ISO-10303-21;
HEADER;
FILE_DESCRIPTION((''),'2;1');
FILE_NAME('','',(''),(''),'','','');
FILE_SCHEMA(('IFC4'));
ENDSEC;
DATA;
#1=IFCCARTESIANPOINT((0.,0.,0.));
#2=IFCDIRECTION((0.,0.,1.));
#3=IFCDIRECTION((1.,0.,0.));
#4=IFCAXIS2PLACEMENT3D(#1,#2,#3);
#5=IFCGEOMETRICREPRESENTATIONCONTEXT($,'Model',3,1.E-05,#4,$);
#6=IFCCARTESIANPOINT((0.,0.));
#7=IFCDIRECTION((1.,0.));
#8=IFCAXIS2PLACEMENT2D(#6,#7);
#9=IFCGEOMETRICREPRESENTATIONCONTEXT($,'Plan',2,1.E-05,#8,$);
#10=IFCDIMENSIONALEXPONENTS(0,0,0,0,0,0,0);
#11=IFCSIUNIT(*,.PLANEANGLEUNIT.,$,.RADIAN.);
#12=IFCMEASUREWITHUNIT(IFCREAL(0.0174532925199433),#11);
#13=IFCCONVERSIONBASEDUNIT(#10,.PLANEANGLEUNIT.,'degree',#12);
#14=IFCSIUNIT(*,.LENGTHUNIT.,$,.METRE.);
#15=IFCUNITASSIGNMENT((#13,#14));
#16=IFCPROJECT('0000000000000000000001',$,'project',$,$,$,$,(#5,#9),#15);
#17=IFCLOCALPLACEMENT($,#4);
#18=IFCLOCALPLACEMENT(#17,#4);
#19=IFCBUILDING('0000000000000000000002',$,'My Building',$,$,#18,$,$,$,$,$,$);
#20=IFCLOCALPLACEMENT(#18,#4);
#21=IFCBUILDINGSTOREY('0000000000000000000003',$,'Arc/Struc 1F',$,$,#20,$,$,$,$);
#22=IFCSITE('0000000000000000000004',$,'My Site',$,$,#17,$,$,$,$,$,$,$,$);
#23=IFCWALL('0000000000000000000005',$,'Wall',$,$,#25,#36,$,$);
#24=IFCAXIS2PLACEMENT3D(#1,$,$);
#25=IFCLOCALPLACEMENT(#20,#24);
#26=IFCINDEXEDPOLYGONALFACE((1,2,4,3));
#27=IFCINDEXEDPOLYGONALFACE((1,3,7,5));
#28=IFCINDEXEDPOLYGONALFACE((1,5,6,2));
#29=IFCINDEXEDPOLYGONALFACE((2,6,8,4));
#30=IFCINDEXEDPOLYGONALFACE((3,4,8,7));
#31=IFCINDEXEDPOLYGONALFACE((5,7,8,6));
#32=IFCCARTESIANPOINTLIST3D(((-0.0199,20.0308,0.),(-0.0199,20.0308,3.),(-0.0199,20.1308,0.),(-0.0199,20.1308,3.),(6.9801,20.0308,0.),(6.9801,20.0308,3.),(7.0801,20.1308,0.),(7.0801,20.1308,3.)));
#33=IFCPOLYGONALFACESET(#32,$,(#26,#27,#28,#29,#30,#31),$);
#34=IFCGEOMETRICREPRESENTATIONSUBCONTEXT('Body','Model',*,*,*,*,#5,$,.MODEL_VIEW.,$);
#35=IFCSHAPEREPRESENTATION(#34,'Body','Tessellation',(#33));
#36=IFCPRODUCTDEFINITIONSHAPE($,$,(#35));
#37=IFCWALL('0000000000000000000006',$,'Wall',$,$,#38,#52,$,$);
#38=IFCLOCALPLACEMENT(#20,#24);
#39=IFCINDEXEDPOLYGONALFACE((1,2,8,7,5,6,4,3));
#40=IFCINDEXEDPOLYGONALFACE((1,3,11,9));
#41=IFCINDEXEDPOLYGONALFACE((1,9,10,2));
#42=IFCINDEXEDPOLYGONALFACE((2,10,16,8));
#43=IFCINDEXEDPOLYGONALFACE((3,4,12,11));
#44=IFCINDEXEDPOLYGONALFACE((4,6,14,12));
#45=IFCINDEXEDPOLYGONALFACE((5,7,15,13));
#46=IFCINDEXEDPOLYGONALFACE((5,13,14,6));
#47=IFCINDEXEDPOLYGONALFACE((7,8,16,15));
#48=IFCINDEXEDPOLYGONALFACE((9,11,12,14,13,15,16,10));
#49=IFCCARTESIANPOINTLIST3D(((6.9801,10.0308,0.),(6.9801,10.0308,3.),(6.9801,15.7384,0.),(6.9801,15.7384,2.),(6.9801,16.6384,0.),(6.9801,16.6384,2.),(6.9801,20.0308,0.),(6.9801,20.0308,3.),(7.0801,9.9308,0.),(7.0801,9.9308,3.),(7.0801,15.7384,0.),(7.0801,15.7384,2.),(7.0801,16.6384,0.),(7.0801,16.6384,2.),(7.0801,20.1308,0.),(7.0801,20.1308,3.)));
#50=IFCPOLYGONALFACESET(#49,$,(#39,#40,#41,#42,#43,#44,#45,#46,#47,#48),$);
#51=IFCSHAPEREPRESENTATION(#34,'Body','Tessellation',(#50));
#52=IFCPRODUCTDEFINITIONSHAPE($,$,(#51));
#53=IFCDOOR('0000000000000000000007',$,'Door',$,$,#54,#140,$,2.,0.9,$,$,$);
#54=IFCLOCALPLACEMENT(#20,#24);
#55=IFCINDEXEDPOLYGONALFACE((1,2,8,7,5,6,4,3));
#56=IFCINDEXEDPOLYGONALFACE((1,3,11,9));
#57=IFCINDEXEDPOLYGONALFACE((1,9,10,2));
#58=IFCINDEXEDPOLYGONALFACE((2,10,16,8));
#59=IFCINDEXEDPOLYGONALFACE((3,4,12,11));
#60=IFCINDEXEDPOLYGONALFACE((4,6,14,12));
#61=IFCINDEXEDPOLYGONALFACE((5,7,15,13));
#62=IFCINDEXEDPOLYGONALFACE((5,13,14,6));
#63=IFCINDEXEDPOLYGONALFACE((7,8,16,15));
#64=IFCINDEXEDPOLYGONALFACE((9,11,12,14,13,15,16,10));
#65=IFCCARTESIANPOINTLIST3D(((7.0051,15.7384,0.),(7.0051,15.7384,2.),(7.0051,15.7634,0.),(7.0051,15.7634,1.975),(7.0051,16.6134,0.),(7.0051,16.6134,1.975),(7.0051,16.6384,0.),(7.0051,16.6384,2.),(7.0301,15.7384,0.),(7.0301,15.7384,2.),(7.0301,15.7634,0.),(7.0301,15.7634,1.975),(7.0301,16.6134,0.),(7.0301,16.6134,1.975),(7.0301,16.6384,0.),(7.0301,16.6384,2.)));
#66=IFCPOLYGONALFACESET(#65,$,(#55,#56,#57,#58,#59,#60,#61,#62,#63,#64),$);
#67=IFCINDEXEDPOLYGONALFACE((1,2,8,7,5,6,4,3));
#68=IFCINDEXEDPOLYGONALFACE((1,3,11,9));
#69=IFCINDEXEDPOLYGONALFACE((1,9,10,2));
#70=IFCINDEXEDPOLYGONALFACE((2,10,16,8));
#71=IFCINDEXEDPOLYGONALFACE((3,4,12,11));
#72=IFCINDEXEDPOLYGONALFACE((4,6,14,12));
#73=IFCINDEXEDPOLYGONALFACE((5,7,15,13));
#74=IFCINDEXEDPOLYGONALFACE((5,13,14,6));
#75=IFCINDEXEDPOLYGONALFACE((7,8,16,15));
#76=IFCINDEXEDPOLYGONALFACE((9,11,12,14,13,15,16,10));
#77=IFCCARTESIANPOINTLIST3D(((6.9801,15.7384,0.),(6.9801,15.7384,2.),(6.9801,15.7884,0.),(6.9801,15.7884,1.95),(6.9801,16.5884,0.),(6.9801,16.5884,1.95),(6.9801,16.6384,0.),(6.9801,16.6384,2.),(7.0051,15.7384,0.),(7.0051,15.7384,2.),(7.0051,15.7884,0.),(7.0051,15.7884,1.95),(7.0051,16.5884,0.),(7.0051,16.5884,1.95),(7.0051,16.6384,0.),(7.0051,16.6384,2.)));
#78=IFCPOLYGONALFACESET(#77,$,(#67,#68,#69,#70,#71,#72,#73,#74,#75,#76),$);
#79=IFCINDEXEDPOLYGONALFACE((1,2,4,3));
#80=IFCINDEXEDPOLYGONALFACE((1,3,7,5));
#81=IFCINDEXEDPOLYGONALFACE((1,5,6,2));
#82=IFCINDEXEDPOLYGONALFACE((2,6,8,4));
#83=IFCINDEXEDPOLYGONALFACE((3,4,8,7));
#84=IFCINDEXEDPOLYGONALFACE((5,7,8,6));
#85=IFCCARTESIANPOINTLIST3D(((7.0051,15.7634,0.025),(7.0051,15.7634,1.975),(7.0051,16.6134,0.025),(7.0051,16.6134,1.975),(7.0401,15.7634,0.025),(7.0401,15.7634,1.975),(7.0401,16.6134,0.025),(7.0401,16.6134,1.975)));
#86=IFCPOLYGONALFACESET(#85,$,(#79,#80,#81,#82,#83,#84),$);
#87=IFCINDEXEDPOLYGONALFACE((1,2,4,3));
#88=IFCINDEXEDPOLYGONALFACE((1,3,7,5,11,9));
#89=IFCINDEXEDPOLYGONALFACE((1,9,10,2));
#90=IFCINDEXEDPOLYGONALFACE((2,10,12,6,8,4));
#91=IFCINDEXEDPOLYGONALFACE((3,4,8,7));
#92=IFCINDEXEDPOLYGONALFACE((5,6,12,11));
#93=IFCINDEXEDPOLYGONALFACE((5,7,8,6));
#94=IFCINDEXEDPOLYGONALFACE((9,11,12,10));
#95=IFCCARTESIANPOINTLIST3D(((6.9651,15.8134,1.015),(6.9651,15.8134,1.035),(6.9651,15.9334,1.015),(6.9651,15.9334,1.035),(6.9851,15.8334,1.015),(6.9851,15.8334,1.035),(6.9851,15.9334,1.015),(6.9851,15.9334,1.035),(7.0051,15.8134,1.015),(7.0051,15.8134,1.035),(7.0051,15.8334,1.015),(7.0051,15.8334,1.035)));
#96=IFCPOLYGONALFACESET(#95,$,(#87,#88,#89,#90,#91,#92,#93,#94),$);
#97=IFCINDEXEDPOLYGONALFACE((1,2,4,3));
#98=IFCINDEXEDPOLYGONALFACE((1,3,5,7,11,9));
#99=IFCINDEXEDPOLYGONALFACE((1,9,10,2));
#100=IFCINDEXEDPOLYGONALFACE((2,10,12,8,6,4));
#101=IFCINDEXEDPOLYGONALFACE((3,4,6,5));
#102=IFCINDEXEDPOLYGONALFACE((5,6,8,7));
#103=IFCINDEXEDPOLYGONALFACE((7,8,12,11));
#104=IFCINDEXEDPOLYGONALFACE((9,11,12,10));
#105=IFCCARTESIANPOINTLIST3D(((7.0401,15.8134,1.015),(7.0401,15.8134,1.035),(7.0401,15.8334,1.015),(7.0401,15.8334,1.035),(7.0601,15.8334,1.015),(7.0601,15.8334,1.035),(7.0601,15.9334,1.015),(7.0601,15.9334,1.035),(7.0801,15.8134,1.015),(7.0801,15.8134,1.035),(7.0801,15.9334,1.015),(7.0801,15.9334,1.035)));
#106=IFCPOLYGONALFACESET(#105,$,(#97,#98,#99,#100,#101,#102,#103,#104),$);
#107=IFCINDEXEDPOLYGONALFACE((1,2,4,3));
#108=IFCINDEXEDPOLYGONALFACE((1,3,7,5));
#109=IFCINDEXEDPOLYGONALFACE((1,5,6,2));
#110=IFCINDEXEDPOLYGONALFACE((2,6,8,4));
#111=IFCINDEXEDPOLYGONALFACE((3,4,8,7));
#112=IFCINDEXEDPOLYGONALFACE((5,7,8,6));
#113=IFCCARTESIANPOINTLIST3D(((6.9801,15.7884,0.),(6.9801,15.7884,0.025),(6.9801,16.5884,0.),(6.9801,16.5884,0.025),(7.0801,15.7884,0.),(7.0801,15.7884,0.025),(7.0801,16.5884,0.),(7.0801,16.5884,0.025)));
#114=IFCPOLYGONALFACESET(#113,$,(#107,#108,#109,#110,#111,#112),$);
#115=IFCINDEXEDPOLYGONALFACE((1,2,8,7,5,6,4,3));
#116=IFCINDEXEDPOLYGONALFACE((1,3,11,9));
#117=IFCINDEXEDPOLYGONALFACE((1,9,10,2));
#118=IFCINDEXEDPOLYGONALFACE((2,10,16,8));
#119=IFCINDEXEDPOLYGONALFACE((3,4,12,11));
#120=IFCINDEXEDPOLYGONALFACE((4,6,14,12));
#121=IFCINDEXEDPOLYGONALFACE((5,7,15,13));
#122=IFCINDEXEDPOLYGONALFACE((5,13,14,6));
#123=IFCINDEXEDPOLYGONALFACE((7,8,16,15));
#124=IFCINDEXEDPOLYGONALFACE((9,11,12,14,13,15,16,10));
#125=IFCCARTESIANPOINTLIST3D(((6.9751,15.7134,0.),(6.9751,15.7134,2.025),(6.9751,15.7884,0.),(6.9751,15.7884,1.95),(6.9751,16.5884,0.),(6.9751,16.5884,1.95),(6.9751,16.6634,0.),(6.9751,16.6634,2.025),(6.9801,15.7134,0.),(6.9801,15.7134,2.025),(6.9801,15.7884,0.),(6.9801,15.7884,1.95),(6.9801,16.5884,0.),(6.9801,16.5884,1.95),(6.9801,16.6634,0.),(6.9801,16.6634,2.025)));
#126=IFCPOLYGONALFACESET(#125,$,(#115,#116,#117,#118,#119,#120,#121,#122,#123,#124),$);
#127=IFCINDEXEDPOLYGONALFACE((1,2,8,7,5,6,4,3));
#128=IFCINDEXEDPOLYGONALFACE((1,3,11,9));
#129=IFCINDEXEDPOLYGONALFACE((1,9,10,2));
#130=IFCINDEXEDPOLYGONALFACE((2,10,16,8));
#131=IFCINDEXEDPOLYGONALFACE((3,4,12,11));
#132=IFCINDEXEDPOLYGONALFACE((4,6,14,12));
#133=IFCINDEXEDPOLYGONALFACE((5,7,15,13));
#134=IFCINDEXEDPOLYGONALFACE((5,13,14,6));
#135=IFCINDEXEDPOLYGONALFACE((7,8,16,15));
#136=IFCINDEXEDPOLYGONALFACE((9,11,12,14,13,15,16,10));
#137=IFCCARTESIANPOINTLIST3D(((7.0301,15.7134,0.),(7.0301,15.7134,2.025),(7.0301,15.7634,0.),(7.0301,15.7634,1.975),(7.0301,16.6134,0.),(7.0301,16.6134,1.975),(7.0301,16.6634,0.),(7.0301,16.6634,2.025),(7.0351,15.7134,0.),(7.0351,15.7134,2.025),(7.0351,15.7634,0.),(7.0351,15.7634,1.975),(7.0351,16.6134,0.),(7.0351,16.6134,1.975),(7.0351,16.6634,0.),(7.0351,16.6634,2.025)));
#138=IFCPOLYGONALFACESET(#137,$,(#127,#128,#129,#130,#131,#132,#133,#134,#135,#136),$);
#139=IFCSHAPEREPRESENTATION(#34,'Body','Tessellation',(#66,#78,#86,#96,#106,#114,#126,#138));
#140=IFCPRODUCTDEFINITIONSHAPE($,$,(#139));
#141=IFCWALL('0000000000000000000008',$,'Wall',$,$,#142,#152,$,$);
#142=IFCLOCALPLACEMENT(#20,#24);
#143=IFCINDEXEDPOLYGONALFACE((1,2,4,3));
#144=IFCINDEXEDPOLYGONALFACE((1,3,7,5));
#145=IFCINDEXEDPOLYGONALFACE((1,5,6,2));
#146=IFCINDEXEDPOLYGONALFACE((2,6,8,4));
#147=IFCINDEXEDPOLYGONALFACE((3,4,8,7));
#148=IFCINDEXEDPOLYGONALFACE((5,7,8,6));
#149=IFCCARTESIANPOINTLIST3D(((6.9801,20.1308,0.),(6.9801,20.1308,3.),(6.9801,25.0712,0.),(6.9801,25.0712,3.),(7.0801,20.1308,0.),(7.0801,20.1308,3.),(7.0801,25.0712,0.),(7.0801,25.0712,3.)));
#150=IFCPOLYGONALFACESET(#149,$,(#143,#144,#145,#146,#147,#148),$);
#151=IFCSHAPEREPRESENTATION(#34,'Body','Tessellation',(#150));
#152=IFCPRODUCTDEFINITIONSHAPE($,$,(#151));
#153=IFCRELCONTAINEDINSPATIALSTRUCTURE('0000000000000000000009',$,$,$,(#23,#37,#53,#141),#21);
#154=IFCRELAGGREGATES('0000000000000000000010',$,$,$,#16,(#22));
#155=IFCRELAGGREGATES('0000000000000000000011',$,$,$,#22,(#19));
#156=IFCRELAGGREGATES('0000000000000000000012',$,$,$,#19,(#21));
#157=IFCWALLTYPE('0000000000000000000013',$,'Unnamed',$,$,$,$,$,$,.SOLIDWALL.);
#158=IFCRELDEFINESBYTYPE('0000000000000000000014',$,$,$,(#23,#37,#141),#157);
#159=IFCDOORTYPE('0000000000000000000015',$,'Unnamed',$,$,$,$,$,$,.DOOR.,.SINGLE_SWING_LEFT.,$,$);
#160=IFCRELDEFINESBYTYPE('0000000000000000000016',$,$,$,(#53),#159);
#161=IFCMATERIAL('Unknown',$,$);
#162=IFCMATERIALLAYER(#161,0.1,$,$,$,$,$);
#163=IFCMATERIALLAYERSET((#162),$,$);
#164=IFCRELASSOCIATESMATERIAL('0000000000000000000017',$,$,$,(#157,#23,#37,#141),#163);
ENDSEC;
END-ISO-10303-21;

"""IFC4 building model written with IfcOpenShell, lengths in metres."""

from ifc_helpers import new_model, entity, si_unit, converted_unit, frame, origin_with_axes, origin_2d_with_axis, place, context, subcontext, project, spatial, line, indexed_curve, outline, extrude, shape, source, transform, mapped, material, layer, layer_set, layer_usage, type_object, type_shapes, element, fill, save


model = new_model("IFC4")

# Units and contexts
model_context = context("Model", 3, precision=1e-05, world=origin_with_axes())
plan_context = context("Plan", 2, precision=1e-05, world=origin_2d_with_axis())
body_context_1 = subcontext(model_context, "Body", "Model", "MODEL_VIEW")
body_context_2 = subcontext(plan_context, "Body", "Plan", "PLAN_VIEW")
ifc_project = project(units=[converted_unit("PLANEANGLEUNIT", "degree", entity("IfcReal", 0.0174532925199433), si_unit("PLANEANGLEUNIT", "RADIAN"), dimensions=[0, 0, 0, 0, 0, 0, 0]), si_unit("LENGTHUNIT", "METRE")], contexts=[model_context, plan_context])

# Site, building, storey
site_placement = place(None, origin_with_axes())
site = spatial("IfcSite", under=ifc_project, at=site_placement, Name="My Site")
building_placement = place(site_placement, origin_with_axes())
building = spatial("IfcBuilding", under=site, at=building_placement, Name="My Building")
storey_placement = place(building_placement, origin_with_axes())
storey = spatial("IfcBuildingStorey", under=building, at=storey_placement, Name="Arc/Struc 1F")

# Shared definitions
ifc_material = material(Name="Unknown")

# Wall
ifc_layer_1 = layer(ifc_material, 0.1)
ifc_layer_set_1 = layer_set([ifc_layer_1])
wall_type = type_object("IfcWallType", Name="Unnamed", PredefinedType="SOLIDWALL", material=ifc_layer_set_1)
ifc_layer_usage_1 = layer_usage(ifc_layer_set_1, "AXIS2", "POSITIVE", 0.0)
wall_1_placement = place(storey_placement, frame((-0.0199, 20.0308, 0.0), z_axis=(0.0, 0.0, 1.0), x_axis=(1.0, 0.0, 0.0)))
element("IfcWall", 1, at=wall_1_placement, inside=storey, type_object=wall_type, material=ifc_layer_usage_1, Name="Wall", context=body_context_1, shape_type="SweptSolid", body=[
    extrude(outline(indexed_curve([(0.0, 0.0), (0.0, 0.1), (7.1, 0.1), (7.0, 0.0)], segments=[line(1, 2, 3, 4, 1)])), origin_with_axes(), (0.0, 0.0, 1.0), 3.0),
])

# Wall, opening, door
ifc_layer_usage_2 = layer_usage(ifc_layer_set_1, "AXIS2", "POSITIVE", 0.0)
wall_2_placement = place(storey_placement, frame((6.9801, 20.0308, 0.0), z_axis=(0.0, 0.0, 1.0), x_axis=(0.0, -1.0, 0.0)))
wall_2 = element("IfcWall", 2, at=wall_2_placement, inside=storey, type_object=wall_type, material=ifc_layer_usage_2, Name="Wall", context=body_context_1, shape_type="SweptSolid", body=[
    extrude(outline(indexed_curve([(0.0, 0.0), (-0.1, 0.1), (10.1, 0.1), (10.0, 0.0)], segments=[line(1, 2, 3, 4, 1)])), origin_with_axes(), (0.0, 0.0, 1.0), 3.0),
])
shared_shape_1 = source(origin_with_axes(), body_context_1, "Body", "SweptSolid", [
    extrude(outline(indexed_curve([(0.0, 0.0), (0.9, 0.0), (0.9, 2.0), (0.0, 2.0)], segments=[line(1, 2, 3, 4, 1)])), frame((0.0, -0.6, 0.0), z_axis=(0.0, -1.0, 0.0), x_axis=(1.0, 0.0, 0.0)), (0.0, 0.0, -1.0), 1.2),
])
opening_1_placement = place(wall_2_placement, frame((3.3924, 0.0, 0.0), z_axis=(0.0, 0.0, 1.0), x_axis=(1.0, 0.0, 0.0)))
opening_1 = element("IfcOpeningElement", 3, at=opening_1_placement, cuts=wall_2, PredefinedType="OPENING", context=body_context_1, shape_type="MappedRepresentation", body=[
    mapped(shared_shape_1, transform((0.0, 0.0, 0.0), x_axis=(1.0, 0.0, 0.0), y_axis=(0.0, 1.0, 0.0), z_axis=(0.0, 0.0, 1.0), scale=1.0)),
])
door_type = type_object("IfcDoorType", Name="Unnamed", OperationType="SINGLE_SWING_LEFT", PredefinedType="DOOR")
shared_shape_2 = source(origin_with_axes(), body_context_1, "Body", "SweptSolid", [
    extrude(outline(indexed_curve([(0.0, 0.0), (0.0, 2.0), (0.9, 2.0), (0.9, 0.0), (0.875, 0.0), (0.875, 1.975), (0.025, 1.975), (0.025, 0.0)], segments=[line(1, 2, 3, 4, 5, 6, 7, 8, 1)])), frame((0.0, 0.025, 0.0), z_axis=(0.0, -1.0, 0.0), x_axis=(1.0, 0.0, 0.0)), (0.0, 0.0, -1.0), 0.025),
    extrude(outline(indexed_curve([(0.0, 0.0), (0.0, 2.0), (0.9, 2.0), (0.9, 0.0), (0.85, 0.0), (0.85, 1.95), (0.05, 1.95), (0.05, 0.0)], segments=[line(1, 2, 3, 4, 5, 6, 7, 8, 1)])), frame((0.0, 0.0, 0.0), z_axis=(0.0, -1.0, 0.0), x_axis=(1.0, 0.0, 0.0)), (0.0, 0.0, -1.0), 0.025),
    extrude(outline(indexed_curve([(0.0, 0.0), (0.85, 0.0), (0.85, 0.035), (0.0, 0.035)], segments=[line(1, 2, 3, 4, 1)])), frame((0.025, 0.025, 0.025), z_axis=(0.0, 0.0, 1.0), x_axis=(1.0, 0.0, 0.0)), (0.0, 0.0, 1.0), 1.95),
    extrude(outline(indexed_curve([(0.0, 0.0), (0.0, -0.04), (-0.12, -0.04), (-0.12, -0.02), (-0.02, -0.02), (-0.02, 0.0)], segments=[line(1, 2, 3, 4, 5, 6, 1)])), frame((0.825, 0.025, 1.015), z_axis=(0.0, 0.0, 1.0), x_axis=(1.0, 0.0, 0.0)), (0.0, 0.0, 1.0), 0.02),
    extrude(outline(indexed_curve([(0.0, 0.0), (0.0, 0.04), (-0.12, 0.04), (-0.12, 0.02), (-0.02, 0.02), (-0.02, 0.0)], segments=[line(1, 2, 3, 4, 5, 6, 1)])), frame((0.825, 0.06, 1.015), z_axis=(0.0, 0.0, 1.0), x_axis=(1.0, 0.0, 0.0)), (0.0, 0.0, 1.0), 0.02),
    extrude(outline(indexed_curve([(0.0, 0.0), (0.8, 0.0), (0.8, 0.1), (0.0, 0.1)], segments=[line(1, 2, 3, 4, 1)])), frame((0.05, 0.0, 0.0), z_axis=(0.0, 0.0, 1.0), x_axis=(1.0, 0.0, 0.0)), (0.0, 0.0, 1.0), 0.025),
    extrude(outline(indexed_curve([(0.0, 0.0), (0.0, 2.025), (0.95, 2.025), (0.95, 0.0), (0.875, 0.0), (0.875, 1.95), (0.075, 1.95), (0.075, 0.0)], segments=[line(1, 2, 3, 4, 5, 6, 7, 8, 1)])), frame((-0.025, -0.005, 0.0), z_axis=(0.0, -1.0, 0.0), x_axis=(1.0, 0.0, 0.0)), (0.0, 0.0, -1.0), 0.005),
    extrude(outline(indexed_curve([(0.0, 0.0), (0.0, 2.025), (0.95, 2.025), (0.95, 0.0), (0.9, 0.0), (0.9, 1.975), (0.05, 1.975), (0.05, 0.0)], segments=[line(1, 2, 3, 4, 5, 6, 7, 8, 1)])), frame((-0.025, 0.05, 0.0), z_axis=(0.0, -1.0, 0.0), x_axis=(1.0, 0.0, 0.0)), (0.0, 0.0, -1.0), 0.005),
])
shared_shape_3 = source(origin_with_axes(), body_context_2, "Body", "Curve2D", [
    entity("IfcIndexedPolyCurve", entity("IfcCartesianPointList2D", [[0.0, 0.0], [0.0, 0.05], [0.025, 0.05], [0.025, 0.025], [0.05, 0.025], [0.05, 0.0]]), [entity("IfcLineIndex", [1, 2, 3, 4, 5, 6, 1])]),
    entity("IfcIndexedPolyCurve", entity("IfcCartesianPointList2D", [[0.9, 0.0], [0.9, 0.05], [0.875, 0.05], [0.875, 0.025], [0.85, 0.025], [0.85, 0.0]]), [entity("IfcLineIndex", [1, 2, 3, 4, 5, 6, 1])]),
    entity("IfcTrimmedCurve", entity("IfcEllipse", entity("IfcAxis2Placement2D", entity("IfcCartesianPoint", [0.06, 0.05]), entity("IfcDirection", [1.0, 0.0])), 0.815, 0.85), [entity("IfcCartesianPoint", [0.875, 0.05])], [entity("IfcCartesianPoint", [0.06, 0.9])], True, "CARTESIAN"),
    entity("IfcIndexedPolyCurve", entity("IfcCartesianPointList2D", [[0.025, 0.05], [0.06, 0.05], [0.06, 0.9], [0.025, 0.9]]), [entity("IfcLineIndex", [1, 2, 3, 4, 1])]),
])
type_shapes(door_type, [shared_shape_2, shared_shape_3])
door_1_placement = place(opening_1_placement, frame((0.0, 0.0, 0.0), z_axis=(0.0, 0.0, 1.0), x_axis=(1.0, 0.0, 0.0)))
door_1 = element("IfcDoor", 4, at=door_1_placement, inside=storey, type_object=door_type, Name="Door", OverallHeight=2.0, OverallWidth=0.9, shapes=[
    shape(body_context_1, "Body", "MappedRepresentation", [mapped(shared_shape_2, transform((0.0, 0.0, 0.0), x_axis=(1.0, 0.0, 0.0), y_axis=(0.0, 1.0, 0.0), z_axis=(0.0, 0.0, 1.0), scale=1.0))]),
    shape(body_context_2, "Body", "MappedRepresentation", [mapped(shared_shape_3, transform((0.0, 0.0, 0.0), x_axis=(1.0, 0.0, 0.0), y_axis=(0.0, 1.0, 0.0), z_axis=(0.0, 0.0, 1.0), scale=1.0))]),
])
fill(opening_1, door_1)

# Wall
ifc_layer_usage_3 = layer_usage(ifc_layer_set_1, "AXIS2", "POSITIVE", 0.0)
wall_3_placement = place(storey_placement, frame((7.0801, 20.1308, 0.0), z_axis=(0.0, 0.0, 1.0), x_axis=(0.0, 1.0, 0.0)))
element("IfcWall", 5, at=wall_3_placement, inside=storey, type_object=wall_type, material=ifc_layer_usage_3, Name="Wall", context=body_context_1, shape_type="SweptSolid", body=[
    extrude(outline(indexed_curve([(0.0, 0.0), (0.0, 0.1), (4.9404, 0.1), (4.9404, 0.0)], segments=[line(1, 2, 3, 4, 1)])), origin_with_axes(), (0.0, 0.0, 1.0), 3.0),
])

save(model, "model.ifc")
